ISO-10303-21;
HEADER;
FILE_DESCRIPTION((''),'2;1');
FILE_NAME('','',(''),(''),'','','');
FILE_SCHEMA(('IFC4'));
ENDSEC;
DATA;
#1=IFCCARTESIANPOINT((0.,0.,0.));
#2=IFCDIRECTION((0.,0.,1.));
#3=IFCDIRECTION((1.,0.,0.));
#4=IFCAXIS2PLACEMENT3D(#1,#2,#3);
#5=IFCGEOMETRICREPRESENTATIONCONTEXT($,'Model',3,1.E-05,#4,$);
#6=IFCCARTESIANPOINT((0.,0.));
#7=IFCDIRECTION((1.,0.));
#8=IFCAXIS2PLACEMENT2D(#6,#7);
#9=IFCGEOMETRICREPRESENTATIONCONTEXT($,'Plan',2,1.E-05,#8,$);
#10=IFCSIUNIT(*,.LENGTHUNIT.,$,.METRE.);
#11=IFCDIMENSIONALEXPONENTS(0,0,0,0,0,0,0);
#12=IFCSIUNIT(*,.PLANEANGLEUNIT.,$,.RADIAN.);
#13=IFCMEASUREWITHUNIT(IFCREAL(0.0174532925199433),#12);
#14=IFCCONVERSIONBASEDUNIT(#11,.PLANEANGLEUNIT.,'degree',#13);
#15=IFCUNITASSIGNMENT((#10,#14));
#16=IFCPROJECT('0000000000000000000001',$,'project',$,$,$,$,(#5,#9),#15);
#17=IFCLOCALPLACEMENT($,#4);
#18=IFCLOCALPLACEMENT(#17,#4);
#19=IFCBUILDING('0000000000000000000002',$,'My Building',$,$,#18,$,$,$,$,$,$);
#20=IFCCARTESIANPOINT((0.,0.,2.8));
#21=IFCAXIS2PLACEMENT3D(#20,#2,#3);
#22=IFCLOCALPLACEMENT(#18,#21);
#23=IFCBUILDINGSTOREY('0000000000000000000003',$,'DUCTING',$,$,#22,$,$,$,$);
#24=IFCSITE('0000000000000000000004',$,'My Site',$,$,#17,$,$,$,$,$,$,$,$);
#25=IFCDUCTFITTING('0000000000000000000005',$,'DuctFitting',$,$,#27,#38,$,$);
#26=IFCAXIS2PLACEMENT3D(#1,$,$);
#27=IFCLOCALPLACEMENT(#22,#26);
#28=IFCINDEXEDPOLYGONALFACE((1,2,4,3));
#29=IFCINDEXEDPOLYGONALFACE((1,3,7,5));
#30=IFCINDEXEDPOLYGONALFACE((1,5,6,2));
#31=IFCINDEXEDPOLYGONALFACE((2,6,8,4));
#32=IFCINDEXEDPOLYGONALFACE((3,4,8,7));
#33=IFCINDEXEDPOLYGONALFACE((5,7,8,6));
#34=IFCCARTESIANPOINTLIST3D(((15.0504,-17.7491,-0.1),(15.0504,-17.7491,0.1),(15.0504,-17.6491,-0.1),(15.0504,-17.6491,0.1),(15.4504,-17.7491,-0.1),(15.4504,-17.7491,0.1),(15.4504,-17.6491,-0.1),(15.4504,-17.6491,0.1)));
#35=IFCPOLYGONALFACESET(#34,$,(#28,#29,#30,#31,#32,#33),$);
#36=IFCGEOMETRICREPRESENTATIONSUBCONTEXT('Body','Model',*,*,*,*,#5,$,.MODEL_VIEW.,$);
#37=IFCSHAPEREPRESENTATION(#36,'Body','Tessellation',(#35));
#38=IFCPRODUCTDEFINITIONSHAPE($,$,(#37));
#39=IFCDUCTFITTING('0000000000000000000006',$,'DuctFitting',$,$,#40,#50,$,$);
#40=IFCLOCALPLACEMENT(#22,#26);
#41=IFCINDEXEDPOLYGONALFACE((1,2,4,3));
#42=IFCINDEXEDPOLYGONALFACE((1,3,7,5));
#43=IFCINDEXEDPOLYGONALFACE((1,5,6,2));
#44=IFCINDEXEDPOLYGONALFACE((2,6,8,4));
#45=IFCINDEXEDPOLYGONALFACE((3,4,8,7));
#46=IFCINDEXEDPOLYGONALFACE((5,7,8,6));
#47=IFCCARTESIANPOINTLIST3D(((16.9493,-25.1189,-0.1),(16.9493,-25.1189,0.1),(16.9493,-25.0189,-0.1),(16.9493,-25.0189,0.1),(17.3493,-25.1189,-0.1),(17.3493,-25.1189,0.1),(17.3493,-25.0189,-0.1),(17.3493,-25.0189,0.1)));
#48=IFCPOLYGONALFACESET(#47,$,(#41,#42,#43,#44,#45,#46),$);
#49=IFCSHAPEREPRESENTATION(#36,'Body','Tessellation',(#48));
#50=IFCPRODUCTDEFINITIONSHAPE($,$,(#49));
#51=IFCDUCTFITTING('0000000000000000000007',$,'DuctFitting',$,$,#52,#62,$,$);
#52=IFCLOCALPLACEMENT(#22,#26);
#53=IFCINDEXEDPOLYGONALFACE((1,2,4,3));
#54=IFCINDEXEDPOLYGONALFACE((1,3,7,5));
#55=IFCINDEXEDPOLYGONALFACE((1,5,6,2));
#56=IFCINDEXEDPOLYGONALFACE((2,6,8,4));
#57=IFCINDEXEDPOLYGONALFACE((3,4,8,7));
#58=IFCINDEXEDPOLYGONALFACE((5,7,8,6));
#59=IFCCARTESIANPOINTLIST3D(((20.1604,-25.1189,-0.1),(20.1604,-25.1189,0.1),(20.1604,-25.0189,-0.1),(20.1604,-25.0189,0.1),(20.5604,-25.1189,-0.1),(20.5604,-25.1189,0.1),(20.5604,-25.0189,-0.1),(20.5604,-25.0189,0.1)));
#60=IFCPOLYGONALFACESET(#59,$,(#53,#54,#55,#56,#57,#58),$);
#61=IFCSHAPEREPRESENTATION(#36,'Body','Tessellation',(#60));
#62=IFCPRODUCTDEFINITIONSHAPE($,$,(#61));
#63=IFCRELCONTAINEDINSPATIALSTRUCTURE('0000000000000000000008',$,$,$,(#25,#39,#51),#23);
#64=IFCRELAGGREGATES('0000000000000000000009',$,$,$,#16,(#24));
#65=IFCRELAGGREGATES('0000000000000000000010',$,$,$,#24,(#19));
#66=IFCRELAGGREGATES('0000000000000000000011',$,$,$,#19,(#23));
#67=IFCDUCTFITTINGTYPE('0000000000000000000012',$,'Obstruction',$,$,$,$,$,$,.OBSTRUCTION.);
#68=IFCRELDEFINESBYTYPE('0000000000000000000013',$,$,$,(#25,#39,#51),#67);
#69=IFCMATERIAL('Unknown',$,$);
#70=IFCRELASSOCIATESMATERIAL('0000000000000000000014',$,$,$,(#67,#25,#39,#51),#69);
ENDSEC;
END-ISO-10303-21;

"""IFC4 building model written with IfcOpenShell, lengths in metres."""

from ifc_helpers import new_model, entity, si_unit, converted_unit, frame, origin_with_axes, origin_2d_with_axis, place, context, subcontext, project, spatial, rectangle, extrude, material, material_profile, profile_set, profile_usage, type_object, element, save


model = new_model("IFC4")

# Units and contexts
model_context = context("Model", 3, precision=1e-05, world=origin_with_axes())
plan_context = context("Plan", 2, precision=1e-05, world=origin_2d_with_axis())
body_context = subcontext(model_context, "Body", "Model", "MODEL_VIEW")
ifc_project = project(units=[si_unit("LENGTHUNIT", "METRE"), converted_unit("PLANEANGLEUNIT", "degree", entity("IfcReal", 0.0174532925199433), si_unit("PLANEANGLEUNIT", "RADIAN"), dimensions=[0, 0, 0, 0, 0, 0, 0])], contexts=[model_context, plan_context])

# Site, building, storey
site_placement = place(None, origin_with_axes())
site = spatial("IfcSite", under=ifc_project, at=site_placement, Name="My Site")
building_placement = place(site_placement, origin_with_axes())
building = spatial("IfcBuilding", under=site, at=building_placement, Name="My Building")
storey_placement = place(building_placement, frame((0.0, 0.0, 2.8), z_axis=(0.0, 0.0, 1.0), x_axis=(1.0, 0.0, 0.0)))
storey = spatial("IfcBuildingStorey", under=building, at=storey_placement, Name="DUCTING")

# Shared definitions
ifc_material = material(Name="Unknown")

# Duct fittings
ifc_material_profile_1 = material_profile(ifc_material, rectangle(XDim=0.4, YDim=0.2))
ifc_profile_set_1 = profile_set([ifc_material_profile_1])
duct_fitting_type_1 = type_object("IfcDuctFittingType", Name="Obstruction", PredefinedType="OBSTRUCTION", material=ifc_profile_set_1)
ifc_profile_usage_1 = profile_usage(ifc_profile_set_1, cardinal=5)
duct_fitting_1_placement = place(storey_placement, frame((15.2504, -17.6491, 0.0), z_axis=(0.0, -1.0, 0.0), x_axis=(1.0, 0.0, 0.0)))
element("IfcDuctFitting", 1, at=duct_fitting_1_placement, inside=storey, type_object=duct_fitting_type_1, material=ifc_profile_usage_1, Name="DuctFitting", context=body_context, shape_type="SweptSolid", body=[
    extrude(rectangle(XDim=0.4, YDim=0.2), origin_with_axes(), (0.0, 0.0, 1.0), 0.1),
])
ifc_profile_usage_2 = profile_usage(ifc_profile_set_1, cardinal=5)
duct_fitting_2_placement = place(storey_placement, frame((17.1493, -25.0189, 0.0), z_axis=(0.000001, -1.0, 0.0), x_axis=(1.0, 0.000001, 0.0)))
element("IfcDuctFitting", 2, at=duct_fitting_2_placement, inside=storey, type_object=duct_fitting_type_1, material=ifc_profile_usage_2, Name="DuctFitting", context=body_context, shape_type="SweptSolid", body=[
    extrude(rectangle(XDim=0.4, YDim=0.2), origin_with_axes(), (0.0, 0.0, 1.0), 0.1),
])
ifc_profile_usage_3 = profile_usage(ifc_profile_set_1, cardinal=5)
duct_fitting_3_placement = place(storey_placement, frame((20.3604, -25.0189, 0.0), z_axis=(0.000001, -1.0, 0.0), x_axis=(1.0, 0.000001, 0.0)))
element("IfcDuctFitting", 3, at=duct_fitting_3_placement, inside=storey, type_object=duct_fitting_type_1, material=ifc_profile_usage_3, Name="DuctFitting", context=body_context, shape_type="SweptSolid", body=[
    extrude(rectangle(XDim=0.4, YDim=0.2), origin_with_axes(), (0.0, 0.0, 1.0), 0.1),
])

save(model, "model.ifc")
